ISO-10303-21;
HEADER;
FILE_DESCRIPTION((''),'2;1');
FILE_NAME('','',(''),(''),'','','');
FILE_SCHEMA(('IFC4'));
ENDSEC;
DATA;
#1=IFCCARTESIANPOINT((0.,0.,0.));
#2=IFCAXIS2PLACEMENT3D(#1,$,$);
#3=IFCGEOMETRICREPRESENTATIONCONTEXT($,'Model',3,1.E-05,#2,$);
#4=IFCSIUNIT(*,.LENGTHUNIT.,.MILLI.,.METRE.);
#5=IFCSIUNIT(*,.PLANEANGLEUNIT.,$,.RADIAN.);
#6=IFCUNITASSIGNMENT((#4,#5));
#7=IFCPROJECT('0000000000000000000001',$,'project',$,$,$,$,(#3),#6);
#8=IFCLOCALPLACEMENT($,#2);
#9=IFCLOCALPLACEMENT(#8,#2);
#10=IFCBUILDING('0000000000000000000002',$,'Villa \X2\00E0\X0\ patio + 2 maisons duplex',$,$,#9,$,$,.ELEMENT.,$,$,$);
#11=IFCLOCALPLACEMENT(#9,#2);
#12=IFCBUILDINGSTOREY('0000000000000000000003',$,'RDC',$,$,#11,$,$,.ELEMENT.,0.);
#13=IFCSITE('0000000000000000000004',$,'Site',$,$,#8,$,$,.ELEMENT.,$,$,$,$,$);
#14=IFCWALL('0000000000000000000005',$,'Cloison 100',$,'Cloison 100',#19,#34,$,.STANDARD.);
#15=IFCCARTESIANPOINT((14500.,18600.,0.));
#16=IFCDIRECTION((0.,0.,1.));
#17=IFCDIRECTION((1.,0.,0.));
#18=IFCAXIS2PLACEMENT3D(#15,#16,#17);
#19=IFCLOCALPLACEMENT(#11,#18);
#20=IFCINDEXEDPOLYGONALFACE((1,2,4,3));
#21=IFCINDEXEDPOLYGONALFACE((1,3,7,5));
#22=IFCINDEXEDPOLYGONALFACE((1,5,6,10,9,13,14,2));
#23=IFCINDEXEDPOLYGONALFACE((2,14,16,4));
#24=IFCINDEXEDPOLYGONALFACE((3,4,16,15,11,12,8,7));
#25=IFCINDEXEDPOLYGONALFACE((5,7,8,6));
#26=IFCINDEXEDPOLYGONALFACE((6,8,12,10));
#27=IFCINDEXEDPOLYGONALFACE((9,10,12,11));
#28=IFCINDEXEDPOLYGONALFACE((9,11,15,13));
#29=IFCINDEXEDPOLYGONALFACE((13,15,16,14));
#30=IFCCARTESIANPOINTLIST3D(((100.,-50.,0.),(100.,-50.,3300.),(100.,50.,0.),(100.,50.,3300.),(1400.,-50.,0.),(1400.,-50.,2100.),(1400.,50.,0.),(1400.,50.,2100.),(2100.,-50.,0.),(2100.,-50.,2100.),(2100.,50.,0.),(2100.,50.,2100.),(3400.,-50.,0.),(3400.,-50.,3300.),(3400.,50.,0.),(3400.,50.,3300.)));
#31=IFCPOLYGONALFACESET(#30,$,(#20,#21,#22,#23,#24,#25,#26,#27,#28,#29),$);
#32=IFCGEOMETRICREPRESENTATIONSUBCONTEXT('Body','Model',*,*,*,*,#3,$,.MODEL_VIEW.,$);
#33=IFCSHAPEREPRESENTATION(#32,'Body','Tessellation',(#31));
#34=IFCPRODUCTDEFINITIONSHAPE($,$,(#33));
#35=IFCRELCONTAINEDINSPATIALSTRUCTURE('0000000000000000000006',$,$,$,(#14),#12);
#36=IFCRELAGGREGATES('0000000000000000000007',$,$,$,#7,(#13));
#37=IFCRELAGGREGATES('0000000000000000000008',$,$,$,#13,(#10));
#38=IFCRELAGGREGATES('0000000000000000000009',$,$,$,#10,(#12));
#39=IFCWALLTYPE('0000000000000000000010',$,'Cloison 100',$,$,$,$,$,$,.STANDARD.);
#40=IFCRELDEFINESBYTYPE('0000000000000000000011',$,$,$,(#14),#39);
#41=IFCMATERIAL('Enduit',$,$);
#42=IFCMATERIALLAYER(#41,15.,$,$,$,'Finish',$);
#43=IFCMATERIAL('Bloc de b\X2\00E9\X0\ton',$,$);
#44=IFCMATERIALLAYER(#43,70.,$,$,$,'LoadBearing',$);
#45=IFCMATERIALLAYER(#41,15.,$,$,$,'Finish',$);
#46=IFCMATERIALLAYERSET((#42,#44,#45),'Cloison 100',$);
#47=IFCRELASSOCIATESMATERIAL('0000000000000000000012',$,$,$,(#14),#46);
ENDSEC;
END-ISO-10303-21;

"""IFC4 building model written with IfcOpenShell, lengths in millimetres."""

from ifc_helpers import new_model, si_unit, frame, frame_2d, origin, place, context, subcontext, project, spatial, polyline, rectangle, outline, extrude, material, layer, layer_set, layer_usage, type_object, element, save


model = new_model("IFC4")

# Units and contexts
model_context = context("Model", 3, precision=1e-05, world=origin())
body_context = subcontext(model_context, "Body", "Model", "MODEL_VIEW")
ifc_project = project(units=[si_unit("LENGTHUNIT", "METRE", prefix="MILLI"), si_unit("PLANEANGLEUNIT", "RADIAN")], contexts=[model_context])

# Site, building, storey
site_placement = place(None, origin())
site = spatial("IfcSite", under=ifc_project, at=site_placement, Name="Site", CompositionType="ELEMENT")
building_placement = place(site_placement, origin())
building = spatial("IfcBuilding", under=site, at=building_placement, Name="Villa à patio + 2 maisons duplex", CompositionType="ELEMENT")
storey_placement = place(building_placement, origin())
storey = spatial("IfcBuildingStorey", under=building, at=storey_placement, Name="RDC", CompositionType="ELEMENT", Elevation=0.0)

# Shared definitions
ifc_material_1 = material(Name="Enduit")
ifc_layer_1 = layer(ifc_material_1, 15.0, Category="Finish")
ifc_material_2 = material(Name="Bloc de béton")
ifc_layer_2 = layer(ifc_material_2, 70.0, Category="LoadBearing")
ifc_layer_3 = layer(ifc_material_1, 15.0, Category="Finish")
ifc_layer_set_1 = layer_set([ifc_layer_1, ifc_layer_2, ifc_layer_3], Name="Cloison 100")
ifc_layer_usage_1 = layer_usage(ifc_layer_set_1, "AXIS2", "NEGATIVE", 50.0)
wall_type_1 = type_object("IfcWallType", Name="Cloison 100", PredefinedType="STANDARD")

# Wall, opening
wall_1_placement = place(storey_placement, frame((14500.0, 18600.0, 0.0), z_axis=(0.0, 0.0, 1.0), x_axis=(1.0, 0.0, 0.0)))
wall_1 = element("IfcWall", 1, at=wall_1_placement, inside=storey, type_object=wall_type_1, material=ifc_layer_usage_1, Name="Cloison 100", ObjectType="Cloison 100", PredefinedType="STANDARD", context=body_context, shape_type="SweptSolid", body=[
    extrude(outline(polyline([(100.0, -50.0), (100.0, 50.0), (3400.0, 50.0), (3400.0, -50.0), (100.0, -50.0)])), origin(), (0.0, 0.0, 1.0), 3300.0),
])
opening_1_placement = place(wall_1_placement, frame((1400.0, 0.0, 0.0), z_axis=(0.0, 0.0, 1.0), x_axis=(1.0, 0.0, 0.0)))
element("IfcOpeningElement", 2, at=opening_1_placement, cuts=wall_1, PredefinedType="OPENING", context=body_context, shape_type="SweptSolid", body=[
    extrude(rectangle(XDim=700.0, YDim=120.0, at=frame_2d((350.0, 0.0))), origin(), (0.0, 0.0, 1.0), 2100.0),
])

save(model, "model.ifc")
